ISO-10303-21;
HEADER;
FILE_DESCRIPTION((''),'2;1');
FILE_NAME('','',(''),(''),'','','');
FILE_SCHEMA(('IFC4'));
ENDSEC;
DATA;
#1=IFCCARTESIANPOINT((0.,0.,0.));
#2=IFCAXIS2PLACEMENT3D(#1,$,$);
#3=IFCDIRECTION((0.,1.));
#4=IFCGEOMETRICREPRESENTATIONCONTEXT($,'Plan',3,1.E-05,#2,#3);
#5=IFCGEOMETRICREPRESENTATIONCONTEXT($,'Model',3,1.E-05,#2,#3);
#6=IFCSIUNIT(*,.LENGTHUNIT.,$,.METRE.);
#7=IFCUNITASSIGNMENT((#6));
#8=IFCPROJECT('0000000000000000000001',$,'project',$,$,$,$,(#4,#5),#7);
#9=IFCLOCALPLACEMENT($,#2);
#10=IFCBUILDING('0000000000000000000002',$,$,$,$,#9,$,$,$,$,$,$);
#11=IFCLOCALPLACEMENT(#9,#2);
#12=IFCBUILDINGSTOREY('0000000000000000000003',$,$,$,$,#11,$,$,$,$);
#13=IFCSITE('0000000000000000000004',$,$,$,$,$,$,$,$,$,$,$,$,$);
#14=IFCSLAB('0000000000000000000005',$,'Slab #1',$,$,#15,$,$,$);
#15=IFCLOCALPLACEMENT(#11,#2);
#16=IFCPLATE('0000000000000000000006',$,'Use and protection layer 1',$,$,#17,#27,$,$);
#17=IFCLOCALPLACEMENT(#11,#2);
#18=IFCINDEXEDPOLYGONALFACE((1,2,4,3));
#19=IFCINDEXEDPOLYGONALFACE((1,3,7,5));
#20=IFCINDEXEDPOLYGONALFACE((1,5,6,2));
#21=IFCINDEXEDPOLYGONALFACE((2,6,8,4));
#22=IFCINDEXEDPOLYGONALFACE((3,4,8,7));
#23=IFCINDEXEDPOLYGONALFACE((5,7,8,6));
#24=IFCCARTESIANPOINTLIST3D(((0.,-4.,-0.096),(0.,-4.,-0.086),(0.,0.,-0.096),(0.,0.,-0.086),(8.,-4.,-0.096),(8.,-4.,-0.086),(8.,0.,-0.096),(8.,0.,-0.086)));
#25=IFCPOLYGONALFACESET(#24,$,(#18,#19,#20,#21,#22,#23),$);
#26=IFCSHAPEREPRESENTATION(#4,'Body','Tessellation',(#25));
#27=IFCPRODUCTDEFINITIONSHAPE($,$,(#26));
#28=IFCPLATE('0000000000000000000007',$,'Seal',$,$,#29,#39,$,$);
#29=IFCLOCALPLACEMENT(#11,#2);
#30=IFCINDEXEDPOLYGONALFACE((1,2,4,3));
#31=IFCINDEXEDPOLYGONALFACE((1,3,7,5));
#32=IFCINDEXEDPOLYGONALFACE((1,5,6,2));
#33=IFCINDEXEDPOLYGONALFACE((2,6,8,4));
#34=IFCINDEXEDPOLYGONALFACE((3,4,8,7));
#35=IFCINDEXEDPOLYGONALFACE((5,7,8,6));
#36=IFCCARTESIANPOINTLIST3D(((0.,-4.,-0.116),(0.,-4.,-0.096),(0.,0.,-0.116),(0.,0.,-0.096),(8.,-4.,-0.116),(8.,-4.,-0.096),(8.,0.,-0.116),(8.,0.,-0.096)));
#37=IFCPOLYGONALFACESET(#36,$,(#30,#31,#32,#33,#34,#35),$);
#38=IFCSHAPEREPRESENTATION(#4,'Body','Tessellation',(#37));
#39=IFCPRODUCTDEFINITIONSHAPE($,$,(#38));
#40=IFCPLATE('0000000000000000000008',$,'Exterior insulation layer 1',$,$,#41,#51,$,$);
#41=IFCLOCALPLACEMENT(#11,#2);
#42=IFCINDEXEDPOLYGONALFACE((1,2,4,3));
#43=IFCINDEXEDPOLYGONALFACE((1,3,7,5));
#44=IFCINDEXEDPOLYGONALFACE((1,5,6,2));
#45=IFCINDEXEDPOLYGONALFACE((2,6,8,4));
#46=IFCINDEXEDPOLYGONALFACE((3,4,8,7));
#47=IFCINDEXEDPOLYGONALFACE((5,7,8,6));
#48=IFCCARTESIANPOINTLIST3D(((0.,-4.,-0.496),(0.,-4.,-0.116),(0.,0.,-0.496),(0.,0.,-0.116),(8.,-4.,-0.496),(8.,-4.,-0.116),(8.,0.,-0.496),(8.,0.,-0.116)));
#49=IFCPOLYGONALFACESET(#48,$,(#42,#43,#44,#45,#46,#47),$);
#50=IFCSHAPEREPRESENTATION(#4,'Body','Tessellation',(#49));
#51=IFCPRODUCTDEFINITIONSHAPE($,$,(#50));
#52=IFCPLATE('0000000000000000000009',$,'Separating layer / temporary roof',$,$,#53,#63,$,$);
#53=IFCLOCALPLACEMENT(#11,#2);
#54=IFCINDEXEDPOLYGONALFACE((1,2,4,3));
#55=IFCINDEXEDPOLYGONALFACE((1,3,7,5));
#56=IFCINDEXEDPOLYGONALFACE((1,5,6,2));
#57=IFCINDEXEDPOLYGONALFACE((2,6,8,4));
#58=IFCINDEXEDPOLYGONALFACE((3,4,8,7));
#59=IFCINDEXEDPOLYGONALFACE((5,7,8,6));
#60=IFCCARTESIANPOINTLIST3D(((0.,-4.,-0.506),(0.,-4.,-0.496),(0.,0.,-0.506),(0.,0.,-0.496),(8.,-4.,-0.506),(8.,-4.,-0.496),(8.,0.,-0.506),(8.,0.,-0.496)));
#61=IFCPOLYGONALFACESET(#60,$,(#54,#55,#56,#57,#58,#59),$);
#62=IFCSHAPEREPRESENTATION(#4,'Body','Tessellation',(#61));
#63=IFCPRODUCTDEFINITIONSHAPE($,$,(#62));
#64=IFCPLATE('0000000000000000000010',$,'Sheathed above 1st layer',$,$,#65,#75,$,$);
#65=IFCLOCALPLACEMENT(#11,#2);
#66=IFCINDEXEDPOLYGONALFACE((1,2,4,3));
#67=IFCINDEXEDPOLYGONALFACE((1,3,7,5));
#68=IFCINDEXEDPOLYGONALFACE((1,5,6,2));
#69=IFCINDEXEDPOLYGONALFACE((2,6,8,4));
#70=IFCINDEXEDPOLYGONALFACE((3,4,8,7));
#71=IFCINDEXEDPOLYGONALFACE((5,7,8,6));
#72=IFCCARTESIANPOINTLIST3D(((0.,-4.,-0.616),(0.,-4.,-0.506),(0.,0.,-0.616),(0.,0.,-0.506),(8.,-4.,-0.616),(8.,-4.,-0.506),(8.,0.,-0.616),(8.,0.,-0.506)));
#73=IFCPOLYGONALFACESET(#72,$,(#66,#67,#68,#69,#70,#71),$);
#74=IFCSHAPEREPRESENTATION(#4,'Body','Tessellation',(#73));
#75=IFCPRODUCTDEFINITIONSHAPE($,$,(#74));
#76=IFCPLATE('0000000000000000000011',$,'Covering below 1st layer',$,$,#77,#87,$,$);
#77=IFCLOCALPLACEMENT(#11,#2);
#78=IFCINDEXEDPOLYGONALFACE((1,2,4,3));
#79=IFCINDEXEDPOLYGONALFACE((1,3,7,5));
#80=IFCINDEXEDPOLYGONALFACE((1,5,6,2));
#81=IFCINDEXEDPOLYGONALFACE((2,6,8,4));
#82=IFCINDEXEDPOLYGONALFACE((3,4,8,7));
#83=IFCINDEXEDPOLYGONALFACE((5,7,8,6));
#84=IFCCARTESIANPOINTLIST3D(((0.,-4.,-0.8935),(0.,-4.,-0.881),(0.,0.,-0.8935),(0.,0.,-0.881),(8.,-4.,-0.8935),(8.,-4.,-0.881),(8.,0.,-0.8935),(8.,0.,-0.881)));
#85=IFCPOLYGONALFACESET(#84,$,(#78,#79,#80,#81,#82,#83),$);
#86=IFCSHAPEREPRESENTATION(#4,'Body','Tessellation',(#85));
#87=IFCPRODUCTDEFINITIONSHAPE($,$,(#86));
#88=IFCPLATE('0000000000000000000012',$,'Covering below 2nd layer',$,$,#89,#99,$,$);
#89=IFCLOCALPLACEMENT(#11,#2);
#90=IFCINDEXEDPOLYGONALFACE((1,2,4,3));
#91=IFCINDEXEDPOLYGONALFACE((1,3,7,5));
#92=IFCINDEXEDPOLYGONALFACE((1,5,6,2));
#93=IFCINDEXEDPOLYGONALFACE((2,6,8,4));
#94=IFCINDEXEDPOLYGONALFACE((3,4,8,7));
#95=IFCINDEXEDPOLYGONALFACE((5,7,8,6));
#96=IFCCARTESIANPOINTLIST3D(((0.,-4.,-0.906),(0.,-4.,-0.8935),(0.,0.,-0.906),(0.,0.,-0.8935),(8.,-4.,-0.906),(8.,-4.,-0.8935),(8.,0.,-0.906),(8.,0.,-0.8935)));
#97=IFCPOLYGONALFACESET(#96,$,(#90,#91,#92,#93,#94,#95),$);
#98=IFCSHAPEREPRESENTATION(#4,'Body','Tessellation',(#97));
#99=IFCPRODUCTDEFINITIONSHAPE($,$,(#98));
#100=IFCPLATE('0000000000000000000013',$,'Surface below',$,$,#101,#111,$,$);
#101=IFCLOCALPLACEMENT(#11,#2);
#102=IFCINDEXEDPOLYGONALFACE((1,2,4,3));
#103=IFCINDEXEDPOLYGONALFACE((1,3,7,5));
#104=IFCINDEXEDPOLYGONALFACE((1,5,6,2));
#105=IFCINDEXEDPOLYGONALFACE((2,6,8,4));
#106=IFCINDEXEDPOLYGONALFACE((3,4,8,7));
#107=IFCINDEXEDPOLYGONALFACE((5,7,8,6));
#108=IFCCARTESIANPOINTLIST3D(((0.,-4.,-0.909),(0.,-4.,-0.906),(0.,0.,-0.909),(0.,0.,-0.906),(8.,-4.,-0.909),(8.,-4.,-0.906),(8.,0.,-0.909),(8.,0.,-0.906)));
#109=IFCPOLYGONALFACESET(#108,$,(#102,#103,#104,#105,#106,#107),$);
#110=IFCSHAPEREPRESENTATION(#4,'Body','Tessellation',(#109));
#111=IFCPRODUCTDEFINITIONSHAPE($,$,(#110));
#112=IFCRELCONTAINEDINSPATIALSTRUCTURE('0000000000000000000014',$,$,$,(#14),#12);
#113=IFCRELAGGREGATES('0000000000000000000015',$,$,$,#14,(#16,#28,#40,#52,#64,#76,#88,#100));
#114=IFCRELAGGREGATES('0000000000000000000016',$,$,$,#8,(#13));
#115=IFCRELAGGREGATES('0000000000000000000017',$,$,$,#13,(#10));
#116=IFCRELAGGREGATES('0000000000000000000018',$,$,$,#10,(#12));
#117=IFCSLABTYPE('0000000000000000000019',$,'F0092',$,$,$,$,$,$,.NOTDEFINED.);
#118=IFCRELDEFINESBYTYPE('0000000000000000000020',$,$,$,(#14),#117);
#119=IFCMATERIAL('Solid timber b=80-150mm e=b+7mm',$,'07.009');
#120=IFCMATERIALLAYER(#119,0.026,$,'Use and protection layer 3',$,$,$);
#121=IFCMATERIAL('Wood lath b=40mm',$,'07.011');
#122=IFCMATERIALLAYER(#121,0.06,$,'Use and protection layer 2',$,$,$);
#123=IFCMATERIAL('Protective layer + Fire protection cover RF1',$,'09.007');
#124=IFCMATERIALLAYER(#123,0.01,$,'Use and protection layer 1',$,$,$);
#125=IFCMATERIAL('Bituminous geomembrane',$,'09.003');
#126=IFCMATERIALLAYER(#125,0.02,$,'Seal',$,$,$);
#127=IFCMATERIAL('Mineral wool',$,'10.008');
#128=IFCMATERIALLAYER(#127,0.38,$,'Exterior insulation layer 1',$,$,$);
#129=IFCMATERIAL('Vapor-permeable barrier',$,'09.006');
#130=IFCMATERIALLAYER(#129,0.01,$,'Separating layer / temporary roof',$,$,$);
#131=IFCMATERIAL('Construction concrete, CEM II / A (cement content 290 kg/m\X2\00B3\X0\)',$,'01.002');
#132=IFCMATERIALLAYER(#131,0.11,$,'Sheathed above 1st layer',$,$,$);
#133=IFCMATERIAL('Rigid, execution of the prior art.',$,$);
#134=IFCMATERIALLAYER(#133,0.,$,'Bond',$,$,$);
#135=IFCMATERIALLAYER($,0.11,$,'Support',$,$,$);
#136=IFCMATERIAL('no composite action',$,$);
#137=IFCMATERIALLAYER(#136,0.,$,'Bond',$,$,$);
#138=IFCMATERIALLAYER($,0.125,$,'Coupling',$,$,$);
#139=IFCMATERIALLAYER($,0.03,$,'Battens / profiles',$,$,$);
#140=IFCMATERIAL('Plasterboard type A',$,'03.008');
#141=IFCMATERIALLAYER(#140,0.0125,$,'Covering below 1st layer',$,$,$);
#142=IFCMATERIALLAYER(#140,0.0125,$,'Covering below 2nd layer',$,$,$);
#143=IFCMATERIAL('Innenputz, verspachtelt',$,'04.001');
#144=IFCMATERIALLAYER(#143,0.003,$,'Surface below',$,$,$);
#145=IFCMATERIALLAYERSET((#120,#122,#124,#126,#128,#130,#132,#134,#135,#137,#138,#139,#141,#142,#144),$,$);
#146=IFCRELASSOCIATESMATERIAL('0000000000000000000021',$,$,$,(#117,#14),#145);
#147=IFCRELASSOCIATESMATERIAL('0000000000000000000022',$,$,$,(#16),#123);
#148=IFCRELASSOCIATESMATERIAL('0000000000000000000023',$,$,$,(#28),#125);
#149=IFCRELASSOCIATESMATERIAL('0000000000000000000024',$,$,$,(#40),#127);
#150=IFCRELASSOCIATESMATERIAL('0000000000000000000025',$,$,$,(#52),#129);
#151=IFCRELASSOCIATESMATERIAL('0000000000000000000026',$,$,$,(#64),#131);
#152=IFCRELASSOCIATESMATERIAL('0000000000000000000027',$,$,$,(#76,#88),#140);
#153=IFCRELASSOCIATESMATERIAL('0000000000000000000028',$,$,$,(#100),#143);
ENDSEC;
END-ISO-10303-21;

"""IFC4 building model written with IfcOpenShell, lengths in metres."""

from ifc_helpers import new_model, si_unit, direction, frame, frame_2d, origin, place, context, project, spatial, rectangle, extrude, material, layer, layer_set, type_object, element, aggregate, save


model = new_model("IFC4")

# Units and contexts
plan_context = context("Plan", 3, precision=1e-05, world=origin(), true_north=direction((0.0, 1.0)))
model_context = context("Model", 3, precision=1e-05, world=origin(), true_north=direction((0.0, 1.0)))
ifc_project = project(units=[si_unit("LENGTHUNIT", "METRE")], contexts=[plan_context, model_context])

# Site, building, storey
site = spatial("IfcSite", under=ifc_project)
building_placement = place(None, origin())
building = spatial("IfcBuilding", under=site, at=building_placement)
storey_placement = place(building_placement, origin())
storey = spatial("IfcBuildingStorey", under=building, at=storey_placement)

# Slab, plates
ifc_material_1 = material(Name="Solid timber b=80-150mm e=b+7mm", Category="07.009")
ifc_layer_1 = layer(ifc_material_1, 0.026, Name="Use and protection layer 3")
ifc_material_2 = material(Name="Wood lath b=40mm", Category="07.011")
ifc_layer_2 = layer(ifc_material_2, 0.06, Name="Use and protection layer 2")
ifc_material_3 = material(Name="Protective layer + Fire protection cover RF1", Category="09.007")
ifc_layer_3 = layer(ifc_material_3, 0.01, Name="Use and protection layer 1")
ifc_material_4 = material(Name="Bituminous geomembrane", Category="09.003")
ifc_layer_4 = layer(ifc_material_4, 0.02, Name="Seal")
ifc_material_5 = material(Name="Mineral wool", Category="10.008")
ifc_layer_5 = layer(ifc_material_5, 0.38, Name="Exterior insulation layer 1")
ifc_material_6 = material(Name="Vapor-permeable barrier", Category="09.006")
ifc_layer_6 = layer(ifc_material_6, 0.01, Name="Separating layer / temporary roof")
ifc_material_7 = material(Name="Construction concrete, CEM II / A (cement content 290 kg/m³)", Category="01.002")
ifc_layer_7 = layer(ifc_material_7, 0.11, Name="Sheathed above 1st layer")
ifc_material_8 = material(Name="Rigid, execution of the prior art.")
ifc_layer_8 = layer(ifc_material_8, 0.0, Name="Bond")
ifc_layer_9 = layer(None, 0.11, Name="Support")
ifc_material_9 = material(Name="no composite action")
ifc_layer_10 = layer(ifc_material_9, 0.0, Name="Bond")
ifc_layer_11 = layer(None, 0.125, Name="Coupling")
ifc_layer_12 = layer(None, 0.03, Name="Battens / profiles")
ifc_material_10 = material(Name="Plasterboard type A", Category="03.008")
ifc_layer_13 = layer(ifc_material_10, 0.0125, Name="Covering below 1st layer")
ifc_layer_14 = layer(ifc_material_10, 0.0125, Name="Covering below 2nd layer")
ifc_material_11 = material(Name="Innenputz, verspachtelt", Category="04.001")
ifc_layer_15 = layer(ifc_material_11, 0.003, Name="Surface below")
ifc_layer_set = layer_set([ifc_layer_1, ifc_layer_2, ifc_layer_3, ifc_layer_4, ifc_layer_5, ifc_layer_6, ifc_layer_7, ifc_layer_8, ifc_layer_9, ifc_layer_10, ifc_layer_11, ifc_layer_12, ifc_layer_13, ifc_layer_14, ifc_layer_15])
slab_type = type_object("IfcSlabType", Name="F0092", PredefinedType="NOTDEFINED", material=ifc_layer_set)
slab_placement = place(None, frame((0.0, 0.0, 0.0), z_axis=(0.0, 0.0, -1.0), x_axis=(1.0, 0.0, 0.0)))
slab = element("IfcSlab", 1, at=slab_placement, inside=storey, type_object=slab_type, material=ifc_layer_set, Name="Slab #1")
plate_1_placement = place(slab_placement, origin())
plate_1 = element("IfcPlate", 2, at=plate_1_placement, material=ifc_material_3, Name="Use and protection layer 1", context=plan_context, shape_type="SweptSolid", body=[
    extrude(rectangle(XDim=8.0, YDim=4.0, at=frame_2d((4.0, 2.0), x_axis=(1.0, 0.0))), frame((0.0, 0.0, 0.086), z_axis=(0.0, 0.0, 1.0), x_axis=(1.0, 0.0, 0.0)), (0.0, 0.0, 1.0), 0.01),
])
plate_2_placement = place(slab_placement, origin())
plate_2 = element("IfcPlate", 3, at=plate_2_placement, material=ifc_material_4, Name="Seal", context=plan_context, shape_type="SweptSolid", body=[
    extrude(rectangle(XDim=8.0, YDim=4.0, at=frame_2d((4.0, 2.0), x_axis=(1.0, 0.0))), frame((0.0, 0.0, 0.096), z_axis=(0.0, 0.0, 1.0), x_axis=(1.0, 0.0, 0.0)), (0.0, 0.0, 1.0), 0.02),
])
plate_3_placement = place(slab_placement, origin())
plate_3 = element("IfcPlate", 4, at=plate_3_placement, material=ifc_material_5, Name="Exterior insulation layer 1", context=plan_context, shape_type="SweptSolid", body=[
    extrude(rectangle(XDim=8.0, YDim=4.0, at=frame_2d((4.0, 2.0), x_axis=(1.0, 0.0))), frame((0.0, 0.0, 0.116), z_axis=(0.0, 0.0, 1.0), x_axis=(1.0, 0.0, 0.0)), (0.0, 0.0, 1.0), 0.38),
])
plate_4_placement = place(slab_placement, origin())
plate_4 = element("IfcPlate", 5, at=plate_4_placement, material=ifc_material_6, Name="Separating layer / temporary roof", context=plan_context, shape_type="SweptSolid", body=[
    extrude(rectangle(XDim=8.0, YDim=4.0, at=frame_2d((4.0, 2.0), x_axis=(1.0, 0.0))), frame((0.0, 0.0, 0.496), z_axis=(0.0, 0.0, 1.0), x_axis=(1.0, 0.0, 0.0)), (0.0, 0.0, 1.0), 0.01),
])
plate_5_placement = place(slab_placement, origin())
plate_5 = element("IfcPlate", 6, at=plate_5_placement, material=ifc_material_7, Name="Sheathed above 1st layer", context=plan_context, shape_type="SweptSolid", body=[
    extrude(rectangle(XDim=8.0, YDim=4.0, at=frame_2d((4.0, 2.0), x_axis=(1.0, 0.0))), frame((0.0, 0.0, 0.506), z_axis=(0.0, 0.0, 1.0), x_axis=(1.0, 0.0, 0.0)), (0.0, 0.0, 1.0), 0.11),
])
plate_6_placement = place(slab_placement, origin())
plate_6 = element("IfcPlate", 7, at=plate_6_placement, material=ifc_material_10, Name="Covering below 1st layer", context=plan_context, shape_type="SweptSolid", body=[
    extrude(rectangle(XDim=8.0, YDim=4.0, at=frame_2d((4.0, 2.0), x_axis=(1.0, 0.0))), frame((0.0, 0.0, 0.881), z_axis=(0.0, 0.0, 1.0), x_axis=(1.0, 0.0, 0.0)), (0.0, 0.0, 1.0), 0.0125),
])
plate_7_placement = place(slab_placement, origin())
plate_7 = element("IfcPlate", 8, at=plate_7_placement, material=ifc_material_10, Name="Covering below 2nd layer", context=plan_context, shape_type="SweptSolid", body=[
    extrude(rectangle(XDim=8.0, YDim=4.0, at=frame_2d((4.0, 2.0), x_axis=(1.0, 0.0))), frame((0.0, 0.0, 0.8935), z_axis=(0.0, 0.0, 1.0), x_axis=(1.0, 0.0, 0.0)), (0.0, 0.0, 1.0), 0.0125),
])
plate_8_placement = place(slab_placement, origin())
plate_8 = element("IfcPlate", 9, at=plate_8_placement, material=ifc_material_11, Name="Surface below", context=plan_context, shape_type="SweptSolid", body=[
    extrude(rectangle(XDim=8.0, YDim=4.0, at=frame_2d((4.0, 2.0), x_axis=(1.0, 0.0))), frame((0.0, 0.0, 0.906), z_axis=(0.0, 0.0, 1.0), x_axis=(1.0, 0.0, 0.0)), (0.0, 0.0, 1.0), 0.003),
])
aggregate(slab, [plate_1, plate_2, plate_3, plate_4, plate_5, plate_6, plate_7, plate_8])

save(model, "model.ifc")
